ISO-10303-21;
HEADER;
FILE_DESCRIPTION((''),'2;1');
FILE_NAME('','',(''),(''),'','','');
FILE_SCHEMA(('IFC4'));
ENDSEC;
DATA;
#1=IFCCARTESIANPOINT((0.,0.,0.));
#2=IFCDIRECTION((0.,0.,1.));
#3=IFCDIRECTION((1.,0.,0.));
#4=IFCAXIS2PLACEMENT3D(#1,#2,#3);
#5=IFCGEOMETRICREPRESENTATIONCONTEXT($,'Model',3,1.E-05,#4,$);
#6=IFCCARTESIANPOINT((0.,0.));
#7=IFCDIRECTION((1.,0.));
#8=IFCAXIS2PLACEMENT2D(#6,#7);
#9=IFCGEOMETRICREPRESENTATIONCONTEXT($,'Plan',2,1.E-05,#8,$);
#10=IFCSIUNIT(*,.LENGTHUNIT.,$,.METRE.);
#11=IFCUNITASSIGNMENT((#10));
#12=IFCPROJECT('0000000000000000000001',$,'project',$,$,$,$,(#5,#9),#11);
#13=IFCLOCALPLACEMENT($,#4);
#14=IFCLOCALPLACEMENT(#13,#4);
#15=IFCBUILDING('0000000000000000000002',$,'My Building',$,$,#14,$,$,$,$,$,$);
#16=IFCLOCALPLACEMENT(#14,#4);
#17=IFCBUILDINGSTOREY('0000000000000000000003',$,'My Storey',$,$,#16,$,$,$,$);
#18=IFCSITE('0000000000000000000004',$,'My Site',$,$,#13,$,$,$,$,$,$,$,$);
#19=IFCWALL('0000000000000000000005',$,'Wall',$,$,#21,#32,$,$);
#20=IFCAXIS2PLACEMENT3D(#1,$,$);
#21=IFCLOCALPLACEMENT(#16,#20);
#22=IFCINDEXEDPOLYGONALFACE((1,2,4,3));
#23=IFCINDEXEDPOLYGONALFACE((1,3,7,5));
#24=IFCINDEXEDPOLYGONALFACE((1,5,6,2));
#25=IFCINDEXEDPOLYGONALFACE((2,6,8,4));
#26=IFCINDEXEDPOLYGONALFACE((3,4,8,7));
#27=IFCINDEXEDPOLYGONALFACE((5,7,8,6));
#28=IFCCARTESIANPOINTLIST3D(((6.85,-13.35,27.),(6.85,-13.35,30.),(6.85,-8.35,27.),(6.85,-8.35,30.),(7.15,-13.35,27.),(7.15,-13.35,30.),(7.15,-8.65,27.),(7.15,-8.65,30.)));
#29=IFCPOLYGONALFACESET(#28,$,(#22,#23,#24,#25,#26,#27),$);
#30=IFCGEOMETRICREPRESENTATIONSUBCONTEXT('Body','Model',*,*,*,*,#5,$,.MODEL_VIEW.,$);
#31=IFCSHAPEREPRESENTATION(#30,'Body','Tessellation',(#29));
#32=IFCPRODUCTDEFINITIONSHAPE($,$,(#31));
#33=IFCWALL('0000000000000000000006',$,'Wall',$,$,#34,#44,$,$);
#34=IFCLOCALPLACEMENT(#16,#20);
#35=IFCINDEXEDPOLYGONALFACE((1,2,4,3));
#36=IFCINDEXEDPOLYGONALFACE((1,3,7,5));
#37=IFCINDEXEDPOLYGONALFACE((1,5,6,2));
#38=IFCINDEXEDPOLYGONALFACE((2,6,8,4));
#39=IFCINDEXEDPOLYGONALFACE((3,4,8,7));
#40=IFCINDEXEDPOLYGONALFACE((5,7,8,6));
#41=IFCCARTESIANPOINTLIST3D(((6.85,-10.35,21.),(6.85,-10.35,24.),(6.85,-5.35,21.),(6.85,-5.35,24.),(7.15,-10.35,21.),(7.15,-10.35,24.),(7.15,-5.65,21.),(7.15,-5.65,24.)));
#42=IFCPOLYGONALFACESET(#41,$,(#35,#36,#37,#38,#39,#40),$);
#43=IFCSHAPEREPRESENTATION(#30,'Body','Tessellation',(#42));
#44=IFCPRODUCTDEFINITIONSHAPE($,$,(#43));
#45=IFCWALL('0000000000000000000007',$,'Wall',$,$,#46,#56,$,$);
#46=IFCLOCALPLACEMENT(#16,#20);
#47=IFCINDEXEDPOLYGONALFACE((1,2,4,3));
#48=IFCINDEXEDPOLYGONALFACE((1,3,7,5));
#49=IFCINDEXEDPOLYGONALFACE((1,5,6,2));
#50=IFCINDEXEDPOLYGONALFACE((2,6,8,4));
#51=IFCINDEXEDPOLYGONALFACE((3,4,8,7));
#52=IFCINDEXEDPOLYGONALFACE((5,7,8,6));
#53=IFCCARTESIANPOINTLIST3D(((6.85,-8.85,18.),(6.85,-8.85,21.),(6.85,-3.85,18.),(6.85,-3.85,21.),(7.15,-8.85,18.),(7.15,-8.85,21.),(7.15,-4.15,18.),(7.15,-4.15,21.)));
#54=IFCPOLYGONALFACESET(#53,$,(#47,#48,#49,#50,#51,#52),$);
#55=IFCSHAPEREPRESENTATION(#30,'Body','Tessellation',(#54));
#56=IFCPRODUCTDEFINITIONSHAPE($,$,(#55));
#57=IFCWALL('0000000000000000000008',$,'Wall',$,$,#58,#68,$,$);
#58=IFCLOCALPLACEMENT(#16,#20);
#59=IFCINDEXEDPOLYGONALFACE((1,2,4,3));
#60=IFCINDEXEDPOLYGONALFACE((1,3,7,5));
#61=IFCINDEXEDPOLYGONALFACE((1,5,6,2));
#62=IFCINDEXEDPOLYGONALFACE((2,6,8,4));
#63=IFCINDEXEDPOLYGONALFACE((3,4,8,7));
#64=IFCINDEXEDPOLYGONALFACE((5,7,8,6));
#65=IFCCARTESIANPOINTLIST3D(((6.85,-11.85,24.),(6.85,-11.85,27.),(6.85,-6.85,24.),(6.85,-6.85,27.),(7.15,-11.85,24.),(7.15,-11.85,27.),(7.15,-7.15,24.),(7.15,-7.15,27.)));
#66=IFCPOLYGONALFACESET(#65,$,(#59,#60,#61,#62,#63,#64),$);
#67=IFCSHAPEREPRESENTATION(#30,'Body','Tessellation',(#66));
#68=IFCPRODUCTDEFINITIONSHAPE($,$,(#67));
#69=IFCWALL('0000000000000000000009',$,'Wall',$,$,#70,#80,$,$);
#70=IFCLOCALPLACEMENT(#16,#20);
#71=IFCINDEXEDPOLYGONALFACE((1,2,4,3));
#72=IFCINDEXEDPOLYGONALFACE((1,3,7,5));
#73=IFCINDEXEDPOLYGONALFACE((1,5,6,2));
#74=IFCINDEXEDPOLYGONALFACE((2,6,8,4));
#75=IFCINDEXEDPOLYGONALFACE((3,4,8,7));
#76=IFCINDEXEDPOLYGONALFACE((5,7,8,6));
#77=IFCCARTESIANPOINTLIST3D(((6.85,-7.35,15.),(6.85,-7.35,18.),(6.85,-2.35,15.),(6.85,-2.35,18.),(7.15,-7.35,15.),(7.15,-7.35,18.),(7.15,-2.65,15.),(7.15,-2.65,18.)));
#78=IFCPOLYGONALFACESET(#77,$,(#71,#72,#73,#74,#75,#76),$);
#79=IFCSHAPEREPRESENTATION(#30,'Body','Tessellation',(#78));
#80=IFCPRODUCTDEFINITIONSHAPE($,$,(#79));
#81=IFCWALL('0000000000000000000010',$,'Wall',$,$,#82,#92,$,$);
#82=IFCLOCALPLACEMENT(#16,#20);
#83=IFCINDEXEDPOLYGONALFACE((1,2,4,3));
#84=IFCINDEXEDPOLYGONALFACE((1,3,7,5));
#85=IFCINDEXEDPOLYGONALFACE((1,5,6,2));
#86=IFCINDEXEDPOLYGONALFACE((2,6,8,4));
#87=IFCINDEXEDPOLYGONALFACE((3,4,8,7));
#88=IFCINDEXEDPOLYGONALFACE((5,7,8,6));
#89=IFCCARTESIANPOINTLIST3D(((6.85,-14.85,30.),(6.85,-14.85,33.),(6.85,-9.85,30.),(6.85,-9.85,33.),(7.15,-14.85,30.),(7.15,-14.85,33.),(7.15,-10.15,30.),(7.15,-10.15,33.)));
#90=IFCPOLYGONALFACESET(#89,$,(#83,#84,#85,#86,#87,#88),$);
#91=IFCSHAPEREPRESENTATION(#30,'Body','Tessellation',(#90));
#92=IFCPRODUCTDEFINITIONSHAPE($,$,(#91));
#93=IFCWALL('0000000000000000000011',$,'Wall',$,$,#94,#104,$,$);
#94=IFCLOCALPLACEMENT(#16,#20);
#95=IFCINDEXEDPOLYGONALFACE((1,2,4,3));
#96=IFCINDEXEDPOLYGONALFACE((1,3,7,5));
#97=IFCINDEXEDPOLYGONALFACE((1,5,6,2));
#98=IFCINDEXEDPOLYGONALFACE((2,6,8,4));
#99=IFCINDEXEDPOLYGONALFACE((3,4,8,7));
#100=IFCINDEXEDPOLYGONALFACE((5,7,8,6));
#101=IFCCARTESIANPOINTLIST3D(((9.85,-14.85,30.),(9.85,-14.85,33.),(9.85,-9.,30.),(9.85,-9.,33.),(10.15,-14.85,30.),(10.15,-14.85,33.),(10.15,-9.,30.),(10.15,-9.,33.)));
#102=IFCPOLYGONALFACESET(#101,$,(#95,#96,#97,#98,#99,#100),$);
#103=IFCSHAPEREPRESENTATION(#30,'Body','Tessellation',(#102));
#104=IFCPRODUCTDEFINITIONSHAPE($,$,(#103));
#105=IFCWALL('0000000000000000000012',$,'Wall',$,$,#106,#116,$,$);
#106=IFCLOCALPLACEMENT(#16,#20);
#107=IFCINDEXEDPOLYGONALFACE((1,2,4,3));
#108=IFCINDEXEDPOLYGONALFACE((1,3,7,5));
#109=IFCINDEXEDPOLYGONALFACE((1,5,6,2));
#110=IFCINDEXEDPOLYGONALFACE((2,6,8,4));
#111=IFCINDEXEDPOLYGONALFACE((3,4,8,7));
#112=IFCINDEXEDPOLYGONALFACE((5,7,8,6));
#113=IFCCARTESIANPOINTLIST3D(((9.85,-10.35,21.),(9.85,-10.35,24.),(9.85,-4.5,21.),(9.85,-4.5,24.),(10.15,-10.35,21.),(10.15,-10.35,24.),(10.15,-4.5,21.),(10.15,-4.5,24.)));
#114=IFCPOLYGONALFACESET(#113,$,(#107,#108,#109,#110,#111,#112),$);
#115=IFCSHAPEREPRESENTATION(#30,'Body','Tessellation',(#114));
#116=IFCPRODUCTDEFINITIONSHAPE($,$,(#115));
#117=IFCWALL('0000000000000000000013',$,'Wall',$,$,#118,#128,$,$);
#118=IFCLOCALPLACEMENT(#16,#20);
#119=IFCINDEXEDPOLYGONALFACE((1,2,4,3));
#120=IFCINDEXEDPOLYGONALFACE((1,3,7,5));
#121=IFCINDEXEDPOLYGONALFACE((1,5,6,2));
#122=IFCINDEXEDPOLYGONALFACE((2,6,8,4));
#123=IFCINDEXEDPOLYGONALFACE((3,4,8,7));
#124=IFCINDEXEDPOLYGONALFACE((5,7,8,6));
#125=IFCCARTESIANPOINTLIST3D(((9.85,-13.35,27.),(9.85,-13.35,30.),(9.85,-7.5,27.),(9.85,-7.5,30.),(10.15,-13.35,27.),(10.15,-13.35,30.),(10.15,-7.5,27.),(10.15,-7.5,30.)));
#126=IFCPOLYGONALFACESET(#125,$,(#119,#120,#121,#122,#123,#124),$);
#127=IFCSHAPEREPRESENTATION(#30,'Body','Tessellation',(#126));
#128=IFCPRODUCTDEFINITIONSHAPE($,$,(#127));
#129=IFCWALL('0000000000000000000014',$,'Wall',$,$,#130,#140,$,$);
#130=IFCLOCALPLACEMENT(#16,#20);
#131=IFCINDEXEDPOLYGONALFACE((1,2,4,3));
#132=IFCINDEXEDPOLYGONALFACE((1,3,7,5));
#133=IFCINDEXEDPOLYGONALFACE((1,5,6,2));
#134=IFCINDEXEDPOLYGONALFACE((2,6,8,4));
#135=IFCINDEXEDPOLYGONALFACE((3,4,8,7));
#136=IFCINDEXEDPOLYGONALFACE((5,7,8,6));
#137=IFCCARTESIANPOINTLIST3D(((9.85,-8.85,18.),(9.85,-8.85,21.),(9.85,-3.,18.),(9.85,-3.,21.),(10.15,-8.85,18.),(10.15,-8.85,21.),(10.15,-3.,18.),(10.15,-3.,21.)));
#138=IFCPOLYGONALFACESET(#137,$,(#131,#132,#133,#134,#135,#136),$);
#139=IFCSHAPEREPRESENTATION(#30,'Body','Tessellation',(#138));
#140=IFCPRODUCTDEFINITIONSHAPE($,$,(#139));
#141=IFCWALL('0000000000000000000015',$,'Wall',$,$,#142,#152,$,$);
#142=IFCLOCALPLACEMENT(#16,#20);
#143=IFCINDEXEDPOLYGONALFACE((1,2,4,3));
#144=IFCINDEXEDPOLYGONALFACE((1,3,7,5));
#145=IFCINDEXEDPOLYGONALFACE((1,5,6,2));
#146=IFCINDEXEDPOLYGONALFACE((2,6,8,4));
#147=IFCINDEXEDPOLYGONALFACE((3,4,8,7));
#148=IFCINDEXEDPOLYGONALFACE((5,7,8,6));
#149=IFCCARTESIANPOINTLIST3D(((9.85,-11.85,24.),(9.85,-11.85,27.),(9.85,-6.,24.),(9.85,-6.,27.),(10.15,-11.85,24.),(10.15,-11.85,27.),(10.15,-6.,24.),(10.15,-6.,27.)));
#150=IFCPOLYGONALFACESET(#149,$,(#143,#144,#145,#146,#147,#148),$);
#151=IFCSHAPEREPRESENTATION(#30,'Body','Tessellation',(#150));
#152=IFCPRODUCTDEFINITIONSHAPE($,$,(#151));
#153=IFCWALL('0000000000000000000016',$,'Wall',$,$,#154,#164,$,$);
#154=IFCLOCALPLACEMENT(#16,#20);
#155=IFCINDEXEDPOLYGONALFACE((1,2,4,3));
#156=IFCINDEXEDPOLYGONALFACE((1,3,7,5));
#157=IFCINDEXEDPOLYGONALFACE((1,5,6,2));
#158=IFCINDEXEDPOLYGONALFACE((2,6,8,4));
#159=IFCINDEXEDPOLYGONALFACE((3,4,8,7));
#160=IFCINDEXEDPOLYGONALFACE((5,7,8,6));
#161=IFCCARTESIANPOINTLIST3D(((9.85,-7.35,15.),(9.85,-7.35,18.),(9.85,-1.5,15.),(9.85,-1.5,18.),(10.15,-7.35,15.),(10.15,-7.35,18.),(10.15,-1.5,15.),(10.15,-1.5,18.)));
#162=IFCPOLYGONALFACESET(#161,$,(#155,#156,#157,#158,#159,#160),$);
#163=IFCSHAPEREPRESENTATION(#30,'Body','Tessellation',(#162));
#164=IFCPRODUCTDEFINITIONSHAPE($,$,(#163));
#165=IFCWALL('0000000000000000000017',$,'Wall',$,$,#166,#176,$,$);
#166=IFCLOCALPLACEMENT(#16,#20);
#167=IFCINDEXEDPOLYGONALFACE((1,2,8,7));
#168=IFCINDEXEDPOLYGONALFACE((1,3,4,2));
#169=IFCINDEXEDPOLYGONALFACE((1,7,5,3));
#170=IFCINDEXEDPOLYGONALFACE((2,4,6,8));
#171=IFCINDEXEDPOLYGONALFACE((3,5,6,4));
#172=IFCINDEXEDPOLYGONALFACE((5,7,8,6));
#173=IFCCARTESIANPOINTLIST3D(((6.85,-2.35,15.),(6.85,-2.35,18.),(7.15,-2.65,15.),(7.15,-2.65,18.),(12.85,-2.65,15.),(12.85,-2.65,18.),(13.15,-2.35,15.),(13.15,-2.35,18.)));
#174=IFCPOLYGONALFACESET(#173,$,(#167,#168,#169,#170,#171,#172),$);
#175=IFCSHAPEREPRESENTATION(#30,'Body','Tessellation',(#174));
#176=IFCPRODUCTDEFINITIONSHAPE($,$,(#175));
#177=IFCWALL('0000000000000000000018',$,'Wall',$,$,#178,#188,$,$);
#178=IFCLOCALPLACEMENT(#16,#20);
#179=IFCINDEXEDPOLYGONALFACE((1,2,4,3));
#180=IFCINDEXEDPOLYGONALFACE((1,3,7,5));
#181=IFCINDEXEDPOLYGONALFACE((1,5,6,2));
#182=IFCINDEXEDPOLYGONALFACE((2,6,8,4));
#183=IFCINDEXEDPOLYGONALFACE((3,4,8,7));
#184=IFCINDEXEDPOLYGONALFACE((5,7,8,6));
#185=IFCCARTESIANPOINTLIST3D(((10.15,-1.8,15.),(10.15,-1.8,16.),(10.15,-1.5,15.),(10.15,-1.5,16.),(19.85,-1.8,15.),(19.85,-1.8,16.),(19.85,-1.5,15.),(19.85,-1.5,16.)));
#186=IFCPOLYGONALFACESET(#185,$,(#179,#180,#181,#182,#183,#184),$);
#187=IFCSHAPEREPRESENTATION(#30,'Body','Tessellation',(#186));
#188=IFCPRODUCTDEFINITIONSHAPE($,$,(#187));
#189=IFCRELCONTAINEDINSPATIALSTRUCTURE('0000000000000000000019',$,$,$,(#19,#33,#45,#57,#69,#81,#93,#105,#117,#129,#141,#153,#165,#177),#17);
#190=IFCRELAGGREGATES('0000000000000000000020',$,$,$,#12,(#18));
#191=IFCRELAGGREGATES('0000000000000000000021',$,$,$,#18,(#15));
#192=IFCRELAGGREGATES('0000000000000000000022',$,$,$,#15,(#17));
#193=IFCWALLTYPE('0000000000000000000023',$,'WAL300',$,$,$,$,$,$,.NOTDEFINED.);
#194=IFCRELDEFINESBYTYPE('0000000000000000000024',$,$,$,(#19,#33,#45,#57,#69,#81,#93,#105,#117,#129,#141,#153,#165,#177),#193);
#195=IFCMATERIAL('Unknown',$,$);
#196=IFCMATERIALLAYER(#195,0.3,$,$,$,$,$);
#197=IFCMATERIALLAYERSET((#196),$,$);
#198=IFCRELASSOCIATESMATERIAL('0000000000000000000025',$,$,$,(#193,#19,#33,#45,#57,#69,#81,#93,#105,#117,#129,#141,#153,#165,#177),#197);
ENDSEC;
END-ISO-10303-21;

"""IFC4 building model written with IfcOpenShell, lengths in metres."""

from ifc_helpers import new_model, si_unit, frame, origin_with_axes, origin_2d_with_axis, place, context, subcontext, project, spatial, line, indexed_curve, outline, extrude, material, layer, layer_set, layer_usage, type_object, element, save


model = new_model("IFC4")

# Units and contexts
model_context = context("Model", 3, precision=1e-05, world=origin_with_axes())
plan_context = context("Plan", 2, precision=1e-05, world=origin_2d_with_axis())
body_context = subcontext(model_context, "Body", "Model", "MODEL_VIEW")
ifc_project = project(units=[si_unit("LENGTHUNIT", "METRE")], contexts=[model_context, plan_context])

# Site, building, storey
site_placement = place(None, origin_with_axes())
site = spatial("IfcSite", under=ifc_project, at=site_placement, Name="My Site")
building_placement = place(site_placement, origin_with_axes())
building = spatial("IfcBuilding", under=site, at=building_placement, Name="My Building")
storey_placement = place(building_placement, origin_with_axes())
storey = spatial("IfcBuildingStorey", under=building, at=storey_placement, Name="My Storey")

# Walls
ifc_material = material(Name="Unknown")
ifc_layer = layer(ifc_material, 0.3)
ifc_layer_set = layer_set([ifc_layer])
ifc_layer_usage_1 = layer_usage(ifc_layer_set, "AXIS2", "POSITIVE", -0.15)
wall_type = type_object("IfcWallType", Name="WAL300", PredefinedType="NOTDEFINED", material=ifc_layer_set)
wall_1_placement = place(storey_placement, frame((7.0, -8.5, 27.0), z_axis=(0.0, 0.0, 1.0), x_axis=(0.0, -1.0, 0.0)))
element("IfcWall", 1, at=wall_1_placement, inside=storey, type_object=wall_type, material=ifc_layer_usage_1, Name="Wall", context=body_context, shape_type="SweptSolid", body=[
    extrude(outline(indexed_curve([(-0.15, -0.15), (0.15, 0.15), (4.85, 0.15), (4.85, -0.15)], segments=[line(1, 2, 3, 4, 1)])), origin_with_axes(), (0.0, 0.0, 1.0), 3.0),
])
ifc_layer_usage_2 = layer_usage(ifc_layer_set, "AXIS2", "POSITIVE", -0.15)
wall_2_placement = place(storey_placement, frame((7.0, -5.5, 21.0), z_axis=(0.0, 0.0, 1.0), x_axis=(0.0, -1.0, 0.0)))
element("IfcWall", 2, at=wall_2_placement, inside=storey, type_object=wall_type, material=ifc_layer_usage_2, Name="Wall", context=body_context, shape_type="SweptSolid", body=[
    extrude(outline(indexed_curve([(-0.15, -0.15), (0.15, 0.15), (4.85, 0.15), (4.85, -0.15)], segments=[line(1, 2, 3, 4, 1)])), origin_with_axes(), (0.0, 0.0, 1.0), 3.0),
])
ifc_layer_usage_3 = layer_usage(ifc_layer_set, "AXIS2", "POSITIVE", -0.15)
wall_3_placement = place(storey_placement, frame((7.0, -4.0, 18.0), z_axis=(0.0, 0.0, 1.0), x_axis=(0.0, -1.0, 0.0)))
element("IfcWall", 3, at=wall_3_placement, inside=storey, type_object=wall_type, material=ifc_layer_usage_3, Name="Wall", context=body_context, shape_type="SweptSolid", body=[
    extrude(outline(indexed_curve([(-0.15, -0.15), (0.15, 0.15), (4.85, 0.15), (4.85, -0.15)], segments=[line(1, 2, 3, 4, 1)])), origin_with_axes(), (0.0, 0.0, 1.0), 3.0),
])
ifc_layer_usage_4 = layer_usage(ifc_layer_set, "AXIS2", "POSITIVE", -0.15)
wall_4_placement = place(storey_placement, frame((7.0, -7.0, 24.0), z_axis=(0.0, 0.0, 1.0), x_axis=(0.0, -1.0, 0.0)))
element("IfcWall", 4, at=wall_4_placement, inside=storey, type_object=wall_type, material=ifc_layer_usage_4, Name="Wall", context=body_context, shape_type="SweptSolid", body=[
    extrude(outline(indexed_curve([(-0.15, -0.15), (0.15, 0.15), (4.85, 0.15), (4.85, -0.15)], segments=[line(1, 2, 3, 4, 1)])), origin_with_axes(), (0.0, 0.0, 1.0), 3.0),
])
ifc_layer_usage_5 = layer_usage(ifc_layer_set, "AXIS2", "POSITIVE", -0.15)
wall_5_placement = place(storey_placement, frame((7.0, -2.5, 15.0), z_axis=(0.0, 0.0, 1.0), x_axis=(0.0, -1.0, 0.0)))
element("IfcWall", 5, at=wall_5_placement, inside=storey, type_object=wall_type, material=ifc_layer_usage_5, Name="Wall", context=body_context, shape_type="SweptSolid", body=[
    extrude(outline(indexed_curve([(-0.15, -0.15), (0.15, 0.15), (4.85, 0.15), (4.85, -0.15)], segments=[line(1, 2, 3, 4, 1)])), origin_with_axes(), (0.0, 0.0, 1.0), 3.0),
])
ifc_layer_usage_6 = layer_usage(ifc_layer_set, "AXIS2", "POSITIVE", -0.15)
wall_6_placement = place(storey_placement, frame((7.0, -10.0, 30.0), z_axis=(0.0, 0.0, 1.0), x_axis=(0.0, -1.0, 0.0)))
element("IfcWall", 6, at=wall_6_placement, inside=storey, type_object=wall_type, material=ifc_layer_usage_6, Name="Wall", context=body_context, shape_type="SweptSolid", body=[
    extrude(outline(indexed_curve([(-0.15, -0.15), (0.15, 0.15), (4.85, 0.15), (4.85, -0.15)], segments=[line(1, 2, 3, 4, 1)])), origin_with_axes(), (0.0, 0.0, 1.0), 3.0),
])
ifc_layer_usage_7 = layer_usage(ifc_layer_set, "AXIS2", "POSITIVE", -0.15)
wall_7_placement = place(storey_placement, frame((10.0, -9.0, 30.0), z_axis=(0.0, 0.0, 1.0), x_axis=(0.0, -1.0, 0.0)))
element("IfcWall", 7, at=wall_7_placement, inside=storey, type_object=wall_type, material=ifc_layer_usage_7, Name="Wall", context=body_context, shape_type="SweptSolid", body=[
    extrude(outline(indexed_curve([(0.0, -0.15), (0.0, 0.15), (5.85, 0.15), (5.85, -0.15)], segments=[line(1, 2, 3, 4, 1)])), origin_with_axes(), (0.0, 0.0, 1.0), 3.0),
])
ifc_layer_usage_8 = layer_usage(ifc_layer_set, "AXIS2", "POSITIVE", -0.15)
wall_8_placement = place(storey_placement, frame((10.0, -4.5, 21.0), z_axis=(0.0, 0.0, 1.0), x_axis=(0.0, -1.0, 0.0)))
element("IfcWall", 8, at=wall_8_placement, inside=storey, type_object=wall_type, material=ifc_layer_usage_8, Name="Wall", context=body_context, shape_type="SweptSolid", body=[
    extrude(outline(indexed_curve([(0.0, -0.15), (0.0, 0.15), (5.85, 0.15), (5.85, -0.15)], segments=[line(1, 2, 3, 4, 1)])), origin_with_axes(), (0.0, 0.0, 1.0), 3.0),
])
ifc_layer_usage_9 = layer_usage(ifc_layer_set, "AXIS2", "POSITIVE", -0.15)
wall_9_placement = place(storey_placement, frame((10.0, -7.5, 27.0), z_axis=(0.0, 0.0, 1.0), x_axis=(0.0, -1.0, 0.0)))
element("IfcWall", 9, at=wall_9_placement, inside=storey, type_object=wall_type, material=ifc_layer_usage_9, Name="Wall", context=body_context, shape_type="SweptSolid", body=[
    extrude(outline(indexed_curve([(0.0, -0.15), (0.0, 0.15), (5.85, 0.15), (5.85, -0.15)], segments=[line(1, 2, 3, 4, 1)])), origin_with_axes(), (0.0, 0.0, 1.0), 3.0),
])
ifc_layer_usage_10 = layer_usage(ifc_layer_set, "AXIS2", "POSITIVE", -0.15)
wall_10_placement = place(storey_placement, frame((10.0, -3.0, 18.0), z_axis=(0.0, 0.0, 1.0), x_axis=(0.0, -1.0, 0.0)))
element("IfcWall", 10, at=wall_10_placement, inside=storey, type_object=wall_type, material=ifc_layer_usage_10, Name="Wall", context=body_context, shape_type="SweptSolid", body=[
    extrude(outline(indexed_curve([(0.0, -0.15), (0.0, 0.15), (5.85, 0.15), (5.85, -0.15)], segments=[line(1, 2, 3, 4, 1)])), origin_with_axes(), (0.0, 0.0, 1.0), 3.0),
])
ifc_layer_usage_11 = layer_usage(ifc_layer_set, "AXIS2", "POSITIVE", -0.15)
wall_11_placement = place(storey_placement, frame((10.0, -6.0, 24.0), z_axis=(0.0, 0.0, 1.0), x_axis=(0.0, -1.0, 0.0)))
element("IfcWall", 11, at=wall_11_placement, inside=storey, type_object=wall_type, material=ifc_layer_usage_11, Name="Wall", context=body_context, shape_type="SweptSolid", body=[
    extrude(outline(indexed_curve([(0.0, -0.15), (0.0, 0.15), (5.85, 0.15), (5.85, -0.15)], segments=[line(1, 2, 3, 4, 1)])), origin_with_axes(), (0.0, 0.0, 1.0), 3.0),
])
ifc_layer_usage_12 = layer_usage(ifc_layer_set, "AXIS2", "POSITIVE", -0.15)
wall_12_placement = place(storey_placement, frame((10.0, -1.5, 15.0), z_axis=(0.0, 0.0, 1.0), x_axis=(0.0, -1.0, 0.0)))
element("IfcWall", 12, at=wall_12_placement, inside=storey, type_object=wall_type, material=ifc_layer_usage_12, Name="Wall", context=body_context, shape_type="SweptSolid", body=[
    extrude(outline(indexed_curve([(0.0, -0.15), (0.0, 0.15), (5.85, 0.15), (5.85, -0.15)], segments=[line(1, 2, 3, 4, 1)])), origin_with_axes(), (0.0, 0.0, 1.0), 3.0),
])
ifc_layer_usage_13 = layer_usage(ifc_layer_set, "AXIS2", "POSITIVE", -0.15)
wall_13_placement = place(storey_placement, frame((7.0, -2.5, 15.0), z_axis=(0.0, 0.0, 1.0), x_axis=(1.0, 0.0, 0.0)))
element("IfcWall", 13, at=wall_13_placement, inside=storey, type_object=wall_type, material=ifc_layer_usage_13, Name="Wall", context=body_context, shape_type="SweptSolid", body=[
    extrude(outline(indexed_curve([(0.15, -0.15), (-0.15, 0.15), (6.15, 0.15), (5.85, -0.15)], segments=[line(1, 2, 3, 4, 1)])), origin_with_axes(), (0.0, 0.0, 1.0), 3.0),
])
ifc_layer_usage_14 = layer_usage(ifc_layer_set, "AXIS2", "POSITIVE", -0.3)
wall_14_placement = place(storey_placement, frame((10.15, -1.5, 15.0), z_axis=(0.0, 0.0, 1.0), x_axis=(1.0, 0.0, 0.0)))
element("IfcWall", 14, at=wall_14_placement, inside=storey, type_object=wall_type, material=ifc_layer_usage_14, Name="Wall", context=body_context, shape_type="SweptSolid", body=[
    extrude(outline(indexed_curve([(0.0, -0.3), (0.0, 0.0), (9.7, 0.0), (9.7, -0.3)], segments=[line(1, 2, 3, 4, 1)])), origin_with_axes(), (0.0, 0.0, 1.0), 1.0),
])

save(model, "model.ifc")
